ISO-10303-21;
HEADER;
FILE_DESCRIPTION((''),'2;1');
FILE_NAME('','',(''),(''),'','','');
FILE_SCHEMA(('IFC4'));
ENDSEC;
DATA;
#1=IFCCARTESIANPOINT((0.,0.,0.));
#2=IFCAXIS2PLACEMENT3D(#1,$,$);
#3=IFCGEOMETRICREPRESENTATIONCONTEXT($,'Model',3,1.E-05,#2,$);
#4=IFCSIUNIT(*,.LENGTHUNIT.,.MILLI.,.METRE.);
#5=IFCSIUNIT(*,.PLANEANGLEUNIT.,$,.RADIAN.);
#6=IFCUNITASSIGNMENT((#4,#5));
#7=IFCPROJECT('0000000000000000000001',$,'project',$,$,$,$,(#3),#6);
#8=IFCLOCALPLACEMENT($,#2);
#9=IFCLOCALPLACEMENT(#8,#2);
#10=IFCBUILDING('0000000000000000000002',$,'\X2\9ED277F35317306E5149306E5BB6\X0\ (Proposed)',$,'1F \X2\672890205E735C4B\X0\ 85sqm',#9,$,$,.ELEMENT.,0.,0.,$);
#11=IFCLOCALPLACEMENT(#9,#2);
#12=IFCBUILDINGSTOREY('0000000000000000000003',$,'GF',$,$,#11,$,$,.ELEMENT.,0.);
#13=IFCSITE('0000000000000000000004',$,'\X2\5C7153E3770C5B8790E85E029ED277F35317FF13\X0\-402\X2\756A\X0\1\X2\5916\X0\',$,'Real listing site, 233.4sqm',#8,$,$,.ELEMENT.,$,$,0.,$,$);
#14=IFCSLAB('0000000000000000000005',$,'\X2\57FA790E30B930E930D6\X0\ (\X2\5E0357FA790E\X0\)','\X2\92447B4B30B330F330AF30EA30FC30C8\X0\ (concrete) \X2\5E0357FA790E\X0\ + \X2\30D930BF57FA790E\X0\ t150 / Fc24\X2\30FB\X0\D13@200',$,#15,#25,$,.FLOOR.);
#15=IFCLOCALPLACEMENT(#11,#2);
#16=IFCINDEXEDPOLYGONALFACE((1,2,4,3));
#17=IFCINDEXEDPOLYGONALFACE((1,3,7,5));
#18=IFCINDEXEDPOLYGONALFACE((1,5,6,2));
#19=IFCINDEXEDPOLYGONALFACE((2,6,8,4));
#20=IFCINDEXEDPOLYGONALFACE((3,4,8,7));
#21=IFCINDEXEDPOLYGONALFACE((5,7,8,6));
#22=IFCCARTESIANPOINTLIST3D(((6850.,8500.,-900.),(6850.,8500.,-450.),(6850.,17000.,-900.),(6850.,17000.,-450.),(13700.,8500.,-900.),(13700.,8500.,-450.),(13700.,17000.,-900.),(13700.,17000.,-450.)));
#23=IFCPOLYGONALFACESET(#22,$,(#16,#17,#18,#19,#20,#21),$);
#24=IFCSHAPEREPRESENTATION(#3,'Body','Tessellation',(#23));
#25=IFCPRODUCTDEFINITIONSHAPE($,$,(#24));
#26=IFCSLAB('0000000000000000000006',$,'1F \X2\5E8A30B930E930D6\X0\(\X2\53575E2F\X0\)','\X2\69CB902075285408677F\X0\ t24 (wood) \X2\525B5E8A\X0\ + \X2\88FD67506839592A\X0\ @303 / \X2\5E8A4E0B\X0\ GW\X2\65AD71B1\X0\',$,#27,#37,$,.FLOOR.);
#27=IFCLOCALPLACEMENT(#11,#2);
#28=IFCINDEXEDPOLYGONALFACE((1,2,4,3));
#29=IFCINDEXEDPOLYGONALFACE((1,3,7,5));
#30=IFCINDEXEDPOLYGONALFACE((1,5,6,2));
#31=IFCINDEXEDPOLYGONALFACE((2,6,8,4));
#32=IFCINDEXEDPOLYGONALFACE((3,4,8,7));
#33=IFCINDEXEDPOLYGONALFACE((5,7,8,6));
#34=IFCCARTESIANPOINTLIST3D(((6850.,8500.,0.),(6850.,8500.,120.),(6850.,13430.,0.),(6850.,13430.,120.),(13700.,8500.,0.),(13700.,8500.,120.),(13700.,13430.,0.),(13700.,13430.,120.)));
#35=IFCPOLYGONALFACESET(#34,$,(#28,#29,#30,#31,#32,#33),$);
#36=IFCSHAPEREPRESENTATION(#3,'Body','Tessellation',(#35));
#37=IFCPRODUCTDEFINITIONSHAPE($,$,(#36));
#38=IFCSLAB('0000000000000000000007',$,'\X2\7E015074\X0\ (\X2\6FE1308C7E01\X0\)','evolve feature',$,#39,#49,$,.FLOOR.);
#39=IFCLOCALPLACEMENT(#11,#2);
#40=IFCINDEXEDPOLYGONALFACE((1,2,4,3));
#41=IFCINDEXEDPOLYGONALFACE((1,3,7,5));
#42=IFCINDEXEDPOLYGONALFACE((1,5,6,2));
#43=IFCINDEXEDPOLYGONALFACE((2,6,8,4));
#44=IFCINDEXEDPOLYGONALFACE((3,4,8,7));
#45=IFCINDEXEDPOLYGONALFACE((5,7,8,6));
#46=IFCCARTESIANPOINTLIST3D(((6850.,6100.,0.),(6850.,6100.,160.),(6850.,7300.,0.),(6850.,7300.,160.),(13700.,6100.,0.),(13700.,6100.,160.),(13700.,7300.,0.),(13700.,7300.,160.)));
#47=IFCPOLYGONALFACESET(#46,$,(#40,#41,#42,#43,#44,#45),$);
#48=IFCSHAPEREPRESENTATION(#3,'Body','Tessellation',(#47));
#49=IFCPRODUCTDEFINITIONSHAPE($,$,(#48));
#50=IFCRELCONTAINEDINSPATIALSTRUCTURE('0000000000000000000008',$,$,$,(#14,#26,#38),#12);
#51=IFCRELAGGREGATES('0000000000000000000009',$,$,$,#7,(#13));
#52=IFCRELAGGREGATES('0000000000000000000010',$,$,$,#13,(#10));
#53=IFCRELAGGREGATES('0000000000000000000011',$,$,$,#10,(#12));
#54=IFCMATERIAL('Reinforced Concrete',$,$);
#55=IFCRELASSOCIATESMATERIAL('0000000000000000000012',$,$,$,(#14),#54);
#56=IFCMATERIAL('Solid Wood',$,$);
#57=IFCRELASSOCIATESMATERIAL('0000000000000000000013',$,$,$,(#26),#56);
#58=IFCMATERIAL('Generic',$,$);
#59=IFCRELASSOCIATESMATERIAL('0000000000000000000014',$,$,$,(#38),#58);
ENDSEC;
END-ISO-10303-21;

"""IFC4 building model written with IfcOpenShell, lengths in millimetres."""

from ifc_helpers import new_model, si_unit, frame, frame_2d, origin, place, context, project, spatial, rectangle, extrude, material, element, save


model = new_model("IFC4")

# Units and contexts
model_context = context("Model", 3, precision=1e-05, world=origin())
ifc_project = project(units=[si_unit("LENGTHUNIT", "METRE", prefix="MILLI"), si_unit("PLANEANGLEUNIT", "RADIAN")], contexts=[model_context])

# Site, building, storey
site_placement = place(None, origin())
site = spatial("IfcSite", under=ifc_project, at=site_placement, Name="山口県宇部市黒石北３-402番1外", ObjectType="Real listing site, 233.4sqm", CompositionType="ELEMENT", RefElevation=0.0)
building_placement = place(site_placement, origin())
building = spatial("IfcBuilding", under=site, at=building_placement, Name="黒石北の光の家 (Proposed)", ObjectType="1F 木造平屋 85sqm", CompositionType="ELEMENT", ElevationOfRefHeight=0.0, ElevationOfTerrain=0.0)
storey_placement = place(building_placement, origin())
storey = spatial("IfcBuildingStorey", under=building, at=storey_placement, Name="GF", CompositionType="ELEMENT", Elevation=0.0)

# Slabs
ifc_material_1 = material(Name="Reinforced Concrete")
slab_1_placement = place(storey_placement, frame((3425.0, 4250.0, -450.0)))
element("IfcSlab", 1, at=slab_1_placement, inside=storey, material=ifc_material_1, Name="基礎スラブ (布基礎)", Description="鉄筋コンクリート (concrete) 布基礎 + ベタ基礎 t150 / Fc24・D13@200", PredefinedType="FLOOR", context=model_context, shape_type="SweptSolid", body=[
    extrude(rectangle(XDim=6850.0, YDim=8500.0, at=frame_2d((3425.0, 4250.0))), frame((3425.0, 4250.0, -450.0)), (0.0, 0.0, 1.0), 450.0),
])
ifc_material_2 = material(Name="Solid Wood")
slab_2_placement = place(storey_placement, frame((3425.0, 4250.0, 0.0)))
element("IfcSlab", 2, at=slab_2_placement, inside=storey, material=ifc_material_2, Name="1F 床スラブ(南帯)", Description="構造用合板 t24 (wood) 剛床 + 製材根太 @303 / 床下 GW断熱", PredefinedType="FLOOR", context=model_context, shape_type="SweptSolid", body=[
    extrude(rectangle(XDim=6850.0, YDim=4930.0, at=frame_2d((3425.0, 2465.0))), frame((3425.0, 4250.0, 0.0)), (0.0, 0.0, 1.0), 120.0),
])
ifc_material_3 = material(Name="Generic")
slab_3_placement = place(storey_placement, frame((3425.0, 3050.0, 0.0)))
element("IfcSlab", 3, at=slab_3_placement, inside=storey, material=ifc_material_3, Name="縁側 (濡れ縁)", Description="evolve feature", PredefinedType="FLOOR", context=model_context, shape_type="SweptSolid", body=[
    extrude(rectangle(XDim=6850.0, YDim=1200.0, at=frame_2d((3425.0, 600.0))), frame((3425.0, 3050.0, 0.0)), (0.0, 0.0, 1.0), 160.0),
])

save(model, "model.ifc")
